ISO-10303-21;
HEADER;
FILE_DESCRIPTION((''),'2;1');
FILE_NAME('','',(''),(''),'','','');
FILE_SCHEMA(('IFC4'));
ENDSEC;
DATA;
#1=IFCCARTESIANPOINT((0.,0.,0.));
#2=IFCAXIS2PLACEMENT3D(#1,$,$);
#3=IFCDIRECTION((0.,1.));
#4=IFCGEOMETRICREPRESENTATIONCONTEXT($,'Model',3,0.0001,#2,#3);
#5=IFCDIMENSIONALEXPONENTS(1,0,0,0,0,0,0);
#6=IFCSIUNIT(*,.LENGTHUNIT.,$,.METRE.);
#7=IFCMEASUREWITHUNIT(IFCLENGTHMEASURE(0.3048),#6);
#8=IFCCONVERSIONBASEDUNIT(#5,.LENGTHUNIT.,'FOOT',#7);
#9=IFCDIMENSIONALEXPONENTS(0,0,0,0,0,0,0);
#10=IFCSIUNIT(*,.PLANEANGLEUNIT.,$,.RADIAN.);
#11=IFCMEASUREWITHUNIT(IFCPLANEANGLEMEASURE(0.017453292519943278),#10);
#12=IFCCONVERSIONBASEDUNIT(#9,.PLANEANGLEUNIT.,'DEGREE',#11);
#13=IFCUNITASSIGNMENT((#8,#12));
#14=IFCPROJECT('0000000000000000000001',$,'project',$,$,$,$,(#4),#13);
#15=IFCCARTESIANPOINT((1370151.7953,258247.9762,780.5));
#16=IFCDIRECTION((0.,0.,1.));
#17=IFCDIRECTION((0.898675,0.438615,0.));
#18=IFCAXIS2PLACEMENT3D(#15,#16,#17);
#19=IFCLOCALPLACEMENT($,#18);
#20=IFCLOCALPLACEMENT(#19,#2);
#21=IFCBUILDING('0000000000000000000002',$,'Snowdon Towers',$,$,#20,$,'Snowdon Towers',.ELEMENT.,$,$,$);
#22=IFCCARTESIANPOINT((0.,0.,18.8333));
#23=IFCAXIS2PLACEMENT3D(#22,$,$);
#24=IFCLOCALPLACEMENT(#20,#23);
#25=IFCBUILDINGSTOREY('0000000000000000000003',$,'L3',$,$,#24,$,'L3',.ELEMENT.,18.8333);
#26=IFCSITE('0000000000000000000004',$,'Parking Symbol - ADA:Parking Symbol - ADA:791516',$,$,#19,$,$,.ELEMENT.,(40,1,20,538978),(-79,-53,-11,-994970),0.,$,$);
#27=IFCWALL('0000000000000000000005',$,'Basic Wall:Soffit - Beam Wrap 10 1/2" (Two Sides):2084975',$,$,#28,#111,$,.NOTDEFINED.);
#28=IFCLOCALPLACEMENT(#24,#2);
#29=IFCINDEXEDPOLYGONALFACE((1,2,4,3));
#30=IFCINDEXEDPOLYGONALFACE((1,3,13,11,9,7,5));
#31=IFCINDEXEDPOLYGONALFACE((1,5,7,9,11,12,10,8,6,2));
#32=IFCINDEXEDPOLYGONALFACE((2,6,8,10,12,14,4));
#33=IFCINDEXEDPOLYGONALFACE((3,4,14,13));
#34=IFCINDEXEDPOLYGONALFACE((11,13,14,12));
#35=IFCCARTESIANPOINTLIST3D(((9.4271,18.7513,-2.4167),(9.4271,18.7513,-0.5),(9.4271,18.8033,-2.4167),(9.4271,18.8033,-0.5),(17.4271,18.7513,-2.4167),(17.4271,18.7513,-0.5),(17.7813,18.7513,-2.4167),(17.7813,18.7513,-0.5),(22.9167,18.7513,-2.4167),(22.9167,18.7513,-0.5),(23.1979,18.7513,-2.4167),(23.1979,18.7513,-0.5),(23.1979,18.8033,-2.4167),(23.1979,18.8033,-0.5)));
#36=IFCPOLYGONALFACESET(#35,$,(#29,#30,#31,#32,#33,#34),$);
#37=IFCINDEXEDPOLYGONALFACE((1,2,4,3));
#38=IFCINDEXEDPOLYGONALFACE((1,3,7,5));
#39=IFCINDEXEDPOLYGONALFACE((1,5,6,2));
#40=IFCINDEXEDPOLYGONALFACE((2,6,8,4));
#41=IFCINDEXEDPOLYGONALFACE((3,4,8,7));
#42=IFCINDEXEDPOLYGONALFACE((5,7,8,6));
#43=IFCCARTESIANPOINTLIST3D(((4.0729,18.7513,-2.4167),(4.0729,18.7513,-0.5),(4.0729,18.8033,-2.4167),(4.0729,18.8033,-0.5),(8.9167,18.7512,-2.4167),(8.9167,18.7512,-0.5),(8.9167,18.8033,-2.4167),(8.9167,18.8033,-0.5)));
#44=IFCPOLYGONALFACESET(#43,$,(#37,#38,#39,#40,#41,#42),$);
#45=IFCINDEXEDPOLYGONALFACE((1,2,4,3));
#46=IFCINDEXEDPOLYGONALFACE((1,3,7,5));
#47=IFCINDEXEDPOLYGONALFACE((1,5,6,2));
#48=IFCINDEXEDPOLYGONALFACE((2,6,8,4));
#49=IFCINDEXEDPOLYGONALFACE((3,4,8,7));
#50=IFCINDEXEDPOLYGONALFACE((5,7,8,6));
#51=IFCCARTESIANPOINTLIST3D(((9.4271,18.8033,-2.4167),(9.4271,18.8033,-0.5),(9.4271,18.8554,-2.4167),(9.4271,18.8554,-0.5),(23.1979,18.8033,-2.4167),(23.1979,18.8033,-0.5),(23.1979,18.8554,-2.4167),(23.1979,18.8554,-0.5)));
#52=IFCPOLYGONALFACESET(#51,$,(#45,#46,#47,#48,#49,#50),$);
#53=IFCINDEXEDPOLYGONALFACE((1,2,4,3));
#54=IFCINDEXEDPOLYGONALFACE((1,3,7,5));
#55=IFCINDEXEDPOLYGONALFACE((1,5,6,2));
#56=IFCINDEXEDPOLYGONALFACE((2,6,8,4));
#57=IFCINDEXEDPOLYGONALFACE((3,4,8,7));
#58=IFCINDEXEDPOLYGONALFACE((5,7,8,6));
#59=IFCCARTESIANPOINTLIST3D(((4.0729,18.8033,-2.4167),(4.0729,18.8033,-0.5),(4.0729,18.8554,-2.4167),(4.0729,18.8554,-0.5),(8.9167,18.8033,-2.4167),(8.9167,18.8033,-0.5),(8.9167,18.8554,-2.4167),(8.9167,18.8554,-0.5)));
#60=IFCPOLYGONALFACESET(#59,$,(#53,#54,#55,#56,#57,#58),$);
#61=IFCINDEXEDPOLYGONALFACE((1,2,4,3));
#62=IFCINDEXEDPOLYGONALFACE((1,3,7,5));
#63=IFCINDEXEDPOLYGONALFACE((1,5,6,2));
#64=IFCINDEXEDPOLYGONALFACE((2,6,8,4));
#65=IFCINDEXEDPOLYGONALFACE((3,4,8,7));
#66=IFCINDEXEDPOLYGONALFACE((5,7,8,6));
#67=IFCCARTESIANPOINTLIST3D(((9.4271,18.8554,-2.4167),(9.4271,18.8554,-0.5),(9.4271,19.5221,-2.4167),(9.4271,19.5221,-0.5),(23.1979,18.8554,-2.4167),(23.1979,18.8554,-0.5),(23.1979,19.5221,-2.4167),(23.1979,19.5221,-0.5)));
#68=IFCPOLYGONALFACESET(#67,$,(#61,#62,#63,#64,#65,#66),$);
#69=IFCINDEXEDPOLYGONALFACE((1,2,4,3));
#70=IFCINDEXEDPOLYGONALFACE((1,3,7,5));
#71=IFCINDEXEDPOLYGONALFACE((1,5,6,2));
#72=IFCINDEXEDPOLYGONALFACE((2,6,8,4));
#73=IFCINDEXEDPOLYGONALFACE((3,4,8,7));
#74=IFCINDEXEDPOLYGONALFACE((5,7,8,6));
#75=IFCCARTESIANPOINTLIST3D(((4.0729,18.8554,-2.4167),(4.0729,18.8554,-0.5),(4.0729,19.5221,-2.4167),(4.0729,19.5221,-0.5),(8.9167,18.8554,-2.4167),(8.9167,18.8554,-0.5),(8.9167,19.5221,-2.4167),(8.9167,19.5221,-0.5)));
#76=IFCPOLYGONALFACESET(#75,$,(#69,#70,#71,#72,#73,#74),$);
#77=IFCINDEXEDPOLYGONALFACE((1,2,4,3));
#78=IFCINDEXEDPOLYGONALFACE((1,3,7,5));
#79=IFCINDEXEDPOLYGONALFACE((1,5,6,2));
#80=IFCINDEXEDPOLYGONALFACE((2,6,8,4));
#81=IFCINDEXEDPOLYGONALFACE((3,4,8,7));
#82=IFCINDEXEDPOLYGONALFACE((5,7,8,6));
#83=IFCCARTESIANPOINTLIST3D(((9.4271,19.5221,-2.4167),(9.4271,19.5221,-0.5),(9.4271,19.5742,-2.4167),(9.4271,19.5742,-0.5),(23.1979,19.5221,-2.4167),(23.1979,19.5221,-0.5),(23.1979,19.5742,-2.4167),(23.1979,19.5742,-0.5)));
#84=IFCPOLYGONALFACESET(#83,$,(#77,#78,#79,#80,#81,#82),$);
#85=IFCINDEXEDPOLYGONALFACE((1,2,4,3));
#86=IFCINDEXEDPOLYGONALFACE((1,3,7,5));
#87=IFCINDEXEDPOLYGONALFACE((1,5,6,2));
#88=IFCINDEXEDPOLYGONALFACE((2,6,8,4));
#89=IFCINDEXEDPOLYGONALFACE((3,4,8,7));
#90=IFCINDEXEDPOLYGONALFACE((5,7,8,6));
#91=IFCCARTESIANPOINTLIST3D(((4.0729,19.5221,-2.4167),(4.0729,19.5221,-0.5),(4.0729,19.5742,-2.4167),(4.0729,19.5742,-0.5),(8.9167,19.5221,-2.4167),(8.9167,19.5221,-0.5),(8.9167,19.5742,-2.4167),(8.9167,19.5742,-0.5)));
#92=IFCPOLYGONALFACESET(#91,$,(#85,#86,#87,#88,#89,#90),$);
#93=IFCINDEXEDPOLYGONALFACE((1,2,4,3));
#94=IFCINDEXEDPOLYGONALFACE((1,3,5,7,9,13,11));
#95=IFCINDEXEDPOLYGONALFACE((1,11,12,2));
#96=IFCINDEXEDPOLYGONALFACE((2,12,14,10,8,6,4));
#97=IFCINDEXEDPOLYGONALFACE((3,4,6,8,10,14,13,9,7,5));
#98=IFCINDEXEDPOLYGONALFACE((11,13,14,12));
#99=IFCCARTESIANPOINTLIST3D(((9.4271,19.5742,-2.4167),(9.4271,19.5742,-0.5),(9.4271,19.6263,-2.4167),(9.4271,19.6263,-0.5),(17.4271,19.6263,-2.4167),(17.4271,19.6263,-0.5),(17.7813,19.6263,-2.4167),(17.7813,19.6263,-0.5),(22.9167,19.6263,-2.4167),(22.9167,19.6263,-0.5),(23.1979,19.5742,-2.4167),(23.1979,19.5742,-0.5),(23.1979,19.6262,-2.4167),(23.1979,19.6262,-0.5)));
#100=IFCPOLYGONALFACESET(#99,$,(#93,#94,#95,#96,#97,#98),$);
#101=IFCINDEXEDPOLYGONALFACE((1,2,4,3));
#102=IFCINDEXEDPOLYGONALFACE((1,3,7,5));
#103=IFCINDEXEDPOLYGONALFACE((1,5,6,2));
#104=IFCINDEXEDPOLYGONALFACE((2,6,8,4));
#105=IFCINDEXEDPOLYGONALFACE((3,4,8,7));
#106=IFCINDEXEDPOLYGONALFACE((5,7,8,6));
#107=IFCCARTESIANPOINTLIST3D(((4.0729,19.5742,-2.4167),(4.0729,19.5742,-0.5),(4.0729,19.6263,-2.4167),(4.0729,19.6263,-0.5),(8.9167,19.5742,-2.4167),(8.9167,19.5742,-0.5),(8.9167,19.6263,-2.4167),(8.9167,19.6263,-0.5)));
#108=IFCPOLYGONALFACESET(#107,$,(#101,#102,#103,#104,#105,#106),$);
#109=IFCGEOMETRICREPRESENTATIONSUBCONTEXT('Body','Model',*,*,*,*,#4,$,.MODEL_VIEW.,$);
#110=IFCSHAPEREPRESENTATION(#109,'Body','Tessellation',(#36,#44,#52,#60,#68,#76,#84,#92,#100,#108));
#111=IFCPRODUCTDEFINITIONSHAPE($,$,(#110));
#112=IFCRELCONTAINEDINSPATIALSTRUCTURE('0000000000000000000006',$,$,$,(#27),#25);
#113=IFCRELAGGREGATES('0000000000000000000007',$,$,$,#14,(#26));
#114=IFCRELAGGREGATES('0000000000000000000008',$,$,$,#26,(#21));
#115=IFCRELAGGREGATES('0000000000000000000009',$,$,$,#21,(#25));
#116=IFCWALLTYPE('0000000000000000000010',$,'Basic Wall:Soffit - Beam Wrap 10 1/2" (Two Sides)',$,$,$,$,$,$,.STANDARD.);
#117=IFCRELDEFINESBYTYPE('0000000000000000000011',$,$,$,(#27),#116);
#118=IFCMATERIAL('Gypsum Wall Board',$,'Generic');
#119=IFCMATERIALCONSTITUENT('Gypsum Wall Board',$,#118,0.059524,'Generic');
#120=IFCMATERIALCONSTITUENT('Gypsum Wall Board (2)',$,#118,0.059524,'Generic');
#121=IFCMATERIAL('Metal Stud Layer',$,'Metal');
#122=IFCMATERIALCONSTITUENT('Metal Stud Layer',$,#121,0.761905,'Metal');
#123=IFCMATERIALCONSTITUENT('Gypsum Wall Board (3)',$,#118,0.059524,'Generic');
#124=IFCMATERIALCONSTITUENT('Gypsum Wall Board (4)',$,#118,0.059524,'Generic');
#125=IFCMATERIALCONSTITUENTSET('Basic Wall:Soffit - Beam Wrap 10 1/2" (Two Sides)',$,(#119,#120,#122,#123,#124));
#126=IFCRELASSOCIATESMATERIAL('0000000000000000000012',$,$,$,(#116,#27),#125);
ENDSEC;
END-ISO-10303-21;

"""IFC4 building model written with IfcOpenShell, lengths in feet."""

from ifc_helpers import new_model, entity, si_unit, converted_unit, direction, frame, origin, place, context, subcontext, project, spatial, indexed_curve, outline, extrude, material, constituent, constituent_set, type_object, element, save


model = new_model("IFC4")

# Units and contexts
model_context = context("Model", 3, precision=0.0001, world=origin(), true_north=direction((0.0, 1.0)))
body_context = subcontext(model_context, "Body", "Model", "MODEL_VIEW")
ifc_project = project(units=[converted_unit("LENGTHUNIT", "FOOT", entity("IfcLengthMeasure", 0.3048), si_unit("LENGTHUNIT", "METRE"), dimensions=[1, 0, 0, 0, 0, 0, 0]), converted_unit("PLANEANGLEUNIT", "DEGREE", entity("IfcPlaneAngleMeasure", 0.017453292519943278), si_unit("PLANEANGLEUNIT", "RADIAN"), dimensions=[0, 0, 0, 0, 0, 0, 0])], contexts=[model_context])

# Site, building, storey
site_placement = place(None, frame((1370151.7953, 258247.9762, 780.5), z_axis=(0.0, 0.0, 1.0), x_axis=(0.898675, 0.438615, 0.0)))
site = spatial("IfcSite", under=ifc_project, at=site_placement, Name="Parking Symbol - ADA:Parking Symbol - ADA:791516", CompositionType="ELEMENT", RefLatitude=(40, 1, 20, 538978), RefLongitude=(-79, -53, -11, -994970), RefElevation=0.0)
building_placement = place(site_placement, origin())
building = spatial("IfcBuilding", under=site, at=building_placement, Name="Snowdon Towers", LongName="Snowdon Towers", CompositionType="ELEMENT")
storey_placement = place(building_placement, frame((0.0, 0.0, 18.8333)))
storey = spatial("IfcBuildingStorey", under=building, at=storey_placement, Name="L3", LongName="L3", CompositionType="ELEMENT", Elevation=18.8333)

# Shared definitions
ifc_material_1 = material(Name="Gypsum Wall Board", Category="Generic")
ifc_material_2 = material(Name="Metal Stud Layer", Category="Metal")

# Wall
ifc_constituent_1 = constituent(ifc_material_1, Name="Gypsum Wall Board", Category="Generic", fraction=0.059524)
ifc_constituent_2 = constituent(ifc_material_1, Name="Gypsum Wall Board (2)", Category="Generic", fraction=0.059524)
ifc_constituent_3 = constituent(ifc_material_2, Name="Metal Stud Layer", Category="Metal", fraction=0.761905)
ifc_constituent_4 = constituent(ifc_material_1, Name="Gypsum Wall Board (3)", Category="Generic", fraction=0.059524)
ifc_constituent_5 = constituent(ifc_material_1, Name="Gypsum Wall Board (4)", Category="Generic", fraction=0.059524)
ifc_constituent_set_1 = constituent_set(constituents=[ifc_constituent_1, ifc_constituent_2, ifc_constituent_3, ifc_constituent_4, ifc_constituent_5], Name="Basic Wall:Soffit - Beam Wrap 10 1/2\" (Two Sides)")
wall_type_1 = type_object("IfcWallType", Name="Basic Wall:Soffit - Beam Wrap 10 1/2\" (Two Sides)", PredefinedType="STANDARD", material=ifc_constituent_set_1)
wall_1_placement = place(storey_placement, frame((4.0729, 19.1887, -2.4167)))
element("IfcWall", 1, at=wall_1_placement, inside=storey, type_object=wall_type_1, material=ifc_constituent_set_1, Name="Basic Wall:Soffit - Beam Wrap 10 1/2\" (Two Sides):2084975", PredefinedType="NOTDEFINED", context=body_context, shape_type="SweptSolid", body=[
    extrude(outline(indexed_curve([(-0.1979, -0.0149), (0.1562, -0.0149), (5.2917, -0.0149), (5.5729, -0.0149), (5.5729, 0.0372), (-8.1979, 0.0372), (-8.1979, -0.0149), (-0.1979, -0.0149)], self_intersect=False)), frame((13.5521, -0.4226, 0.0)), (0.0, 0.0, 1.0), 1.9167),
    extrude(outline(indexed_curve([(-0.026, -2.4219), (0.026, -2.4219), (0.026, 2.4219), (-0.026, 2.4219), (-0.026, -2.4219)], self_intersect=False)), frame((2.4219, -0.4115, 0.0), z_axis=(0.0, 0.0, 1.0), x_axis=(0.0, 1.0, 0.0)), (0.0, 0.0, 1.0), 1.9167),
    extrude(outline(indexed_curve([(-6.8854, -0.026), (6.8854, -0.026), (6.8854, 0.026), (-6.8854, 0.026), (-6.8854, -0.026)], self_intersect=False)), frame((12.2396, -0.3594, 0.0)), (0.0, 0.0, 1.0), 1.9167),
    extrude(outline(indexed_curve([(-2.4219, -0.026), (2.4219, -0.026), (2.4219, 0.026), (-2.4219, 0.026), (-2.4219, -0.026)], self_intersect=False)), frame((2.4219, -0.3594, 0.0)), (0.0, 0.0, 1.0), 1.9167),
    extrude(outline(indexed_curve([(-6.8854, -0.3333), (6.8854, -0.3333), (6.8854, 0.3333), (-6.8854, 0.3333), (-6.8854, -0.3333)], self_intersect=False)), frame((12.2396, 0.0, 0.0)), (0.0, 0.0, 1.0), 1.9167),
    extrude(outline(indexed_curve([(-2.4219, -0.3333), (2.4219, -0.3333), (2.4219, 0.3333), (-2.4219, 0.3333), (-2.4219, -0.3333)], self_intersect=False)), frame((2.4219, 0.0, 0.0)), (0.0, 0.0, 1.0), 1.9167),
    extrude(outline(indexed_curve([(-6.8854, -0.026), (6.8854, -0.026), (6.8854, 0.026), (-6.8854, 0.026), (-6.8854, -0.026)], self_intersect=False)), frame((12.2396, 0.3594, 0.0)), (0.0, 0.0, 1.0), 1.9167),
    extrude(outline(indexed_curve([(-2.4219, -0.026), (2.4219, -0.026), (2.4219, 0.026), (-2.4219, 0.026), (-2.4219, -0.026)], self_intersect=False)), frame((2.4219, 0.3594, 0.0)), (0.0, 0.0, 1.0), 1.9167),
    extrude(outline(indexed_curve([(-5.2917, -0.0149), (-0.1562, -0.0149), (0.1979, -0.0149), (8.1979, -0.0149), (8.1979, 0.0372), (-5.5729, 0.0372), (-5.5729, -0.0149), (-5.2917, -0.0149)], self_intersect=False)), frame((13.5521, 0.4226, 0.0), z_axis=(0.0, 0.0, 1.0), x_axis=(-1.0, 0.0, 0.0)), (0.0, 0.0, 1.0), 1.9167),
    extrude(outline(indexed_curve([(-0.026, -2.4219), (0.026, -2.4219), (0.026, 2.4219), (-0.026, 2.4219), (-0.026, -2.4219)], self_intersect=False)), frame((2.4219, 0.4115, 0.0), z_axis=(0.0, 0.0, 1.0), x_axis=(0.0, -1.0, 0.0)), (0.0, 0.0, 1.0), 1.9167),
])

save(model, "model.ifc")
